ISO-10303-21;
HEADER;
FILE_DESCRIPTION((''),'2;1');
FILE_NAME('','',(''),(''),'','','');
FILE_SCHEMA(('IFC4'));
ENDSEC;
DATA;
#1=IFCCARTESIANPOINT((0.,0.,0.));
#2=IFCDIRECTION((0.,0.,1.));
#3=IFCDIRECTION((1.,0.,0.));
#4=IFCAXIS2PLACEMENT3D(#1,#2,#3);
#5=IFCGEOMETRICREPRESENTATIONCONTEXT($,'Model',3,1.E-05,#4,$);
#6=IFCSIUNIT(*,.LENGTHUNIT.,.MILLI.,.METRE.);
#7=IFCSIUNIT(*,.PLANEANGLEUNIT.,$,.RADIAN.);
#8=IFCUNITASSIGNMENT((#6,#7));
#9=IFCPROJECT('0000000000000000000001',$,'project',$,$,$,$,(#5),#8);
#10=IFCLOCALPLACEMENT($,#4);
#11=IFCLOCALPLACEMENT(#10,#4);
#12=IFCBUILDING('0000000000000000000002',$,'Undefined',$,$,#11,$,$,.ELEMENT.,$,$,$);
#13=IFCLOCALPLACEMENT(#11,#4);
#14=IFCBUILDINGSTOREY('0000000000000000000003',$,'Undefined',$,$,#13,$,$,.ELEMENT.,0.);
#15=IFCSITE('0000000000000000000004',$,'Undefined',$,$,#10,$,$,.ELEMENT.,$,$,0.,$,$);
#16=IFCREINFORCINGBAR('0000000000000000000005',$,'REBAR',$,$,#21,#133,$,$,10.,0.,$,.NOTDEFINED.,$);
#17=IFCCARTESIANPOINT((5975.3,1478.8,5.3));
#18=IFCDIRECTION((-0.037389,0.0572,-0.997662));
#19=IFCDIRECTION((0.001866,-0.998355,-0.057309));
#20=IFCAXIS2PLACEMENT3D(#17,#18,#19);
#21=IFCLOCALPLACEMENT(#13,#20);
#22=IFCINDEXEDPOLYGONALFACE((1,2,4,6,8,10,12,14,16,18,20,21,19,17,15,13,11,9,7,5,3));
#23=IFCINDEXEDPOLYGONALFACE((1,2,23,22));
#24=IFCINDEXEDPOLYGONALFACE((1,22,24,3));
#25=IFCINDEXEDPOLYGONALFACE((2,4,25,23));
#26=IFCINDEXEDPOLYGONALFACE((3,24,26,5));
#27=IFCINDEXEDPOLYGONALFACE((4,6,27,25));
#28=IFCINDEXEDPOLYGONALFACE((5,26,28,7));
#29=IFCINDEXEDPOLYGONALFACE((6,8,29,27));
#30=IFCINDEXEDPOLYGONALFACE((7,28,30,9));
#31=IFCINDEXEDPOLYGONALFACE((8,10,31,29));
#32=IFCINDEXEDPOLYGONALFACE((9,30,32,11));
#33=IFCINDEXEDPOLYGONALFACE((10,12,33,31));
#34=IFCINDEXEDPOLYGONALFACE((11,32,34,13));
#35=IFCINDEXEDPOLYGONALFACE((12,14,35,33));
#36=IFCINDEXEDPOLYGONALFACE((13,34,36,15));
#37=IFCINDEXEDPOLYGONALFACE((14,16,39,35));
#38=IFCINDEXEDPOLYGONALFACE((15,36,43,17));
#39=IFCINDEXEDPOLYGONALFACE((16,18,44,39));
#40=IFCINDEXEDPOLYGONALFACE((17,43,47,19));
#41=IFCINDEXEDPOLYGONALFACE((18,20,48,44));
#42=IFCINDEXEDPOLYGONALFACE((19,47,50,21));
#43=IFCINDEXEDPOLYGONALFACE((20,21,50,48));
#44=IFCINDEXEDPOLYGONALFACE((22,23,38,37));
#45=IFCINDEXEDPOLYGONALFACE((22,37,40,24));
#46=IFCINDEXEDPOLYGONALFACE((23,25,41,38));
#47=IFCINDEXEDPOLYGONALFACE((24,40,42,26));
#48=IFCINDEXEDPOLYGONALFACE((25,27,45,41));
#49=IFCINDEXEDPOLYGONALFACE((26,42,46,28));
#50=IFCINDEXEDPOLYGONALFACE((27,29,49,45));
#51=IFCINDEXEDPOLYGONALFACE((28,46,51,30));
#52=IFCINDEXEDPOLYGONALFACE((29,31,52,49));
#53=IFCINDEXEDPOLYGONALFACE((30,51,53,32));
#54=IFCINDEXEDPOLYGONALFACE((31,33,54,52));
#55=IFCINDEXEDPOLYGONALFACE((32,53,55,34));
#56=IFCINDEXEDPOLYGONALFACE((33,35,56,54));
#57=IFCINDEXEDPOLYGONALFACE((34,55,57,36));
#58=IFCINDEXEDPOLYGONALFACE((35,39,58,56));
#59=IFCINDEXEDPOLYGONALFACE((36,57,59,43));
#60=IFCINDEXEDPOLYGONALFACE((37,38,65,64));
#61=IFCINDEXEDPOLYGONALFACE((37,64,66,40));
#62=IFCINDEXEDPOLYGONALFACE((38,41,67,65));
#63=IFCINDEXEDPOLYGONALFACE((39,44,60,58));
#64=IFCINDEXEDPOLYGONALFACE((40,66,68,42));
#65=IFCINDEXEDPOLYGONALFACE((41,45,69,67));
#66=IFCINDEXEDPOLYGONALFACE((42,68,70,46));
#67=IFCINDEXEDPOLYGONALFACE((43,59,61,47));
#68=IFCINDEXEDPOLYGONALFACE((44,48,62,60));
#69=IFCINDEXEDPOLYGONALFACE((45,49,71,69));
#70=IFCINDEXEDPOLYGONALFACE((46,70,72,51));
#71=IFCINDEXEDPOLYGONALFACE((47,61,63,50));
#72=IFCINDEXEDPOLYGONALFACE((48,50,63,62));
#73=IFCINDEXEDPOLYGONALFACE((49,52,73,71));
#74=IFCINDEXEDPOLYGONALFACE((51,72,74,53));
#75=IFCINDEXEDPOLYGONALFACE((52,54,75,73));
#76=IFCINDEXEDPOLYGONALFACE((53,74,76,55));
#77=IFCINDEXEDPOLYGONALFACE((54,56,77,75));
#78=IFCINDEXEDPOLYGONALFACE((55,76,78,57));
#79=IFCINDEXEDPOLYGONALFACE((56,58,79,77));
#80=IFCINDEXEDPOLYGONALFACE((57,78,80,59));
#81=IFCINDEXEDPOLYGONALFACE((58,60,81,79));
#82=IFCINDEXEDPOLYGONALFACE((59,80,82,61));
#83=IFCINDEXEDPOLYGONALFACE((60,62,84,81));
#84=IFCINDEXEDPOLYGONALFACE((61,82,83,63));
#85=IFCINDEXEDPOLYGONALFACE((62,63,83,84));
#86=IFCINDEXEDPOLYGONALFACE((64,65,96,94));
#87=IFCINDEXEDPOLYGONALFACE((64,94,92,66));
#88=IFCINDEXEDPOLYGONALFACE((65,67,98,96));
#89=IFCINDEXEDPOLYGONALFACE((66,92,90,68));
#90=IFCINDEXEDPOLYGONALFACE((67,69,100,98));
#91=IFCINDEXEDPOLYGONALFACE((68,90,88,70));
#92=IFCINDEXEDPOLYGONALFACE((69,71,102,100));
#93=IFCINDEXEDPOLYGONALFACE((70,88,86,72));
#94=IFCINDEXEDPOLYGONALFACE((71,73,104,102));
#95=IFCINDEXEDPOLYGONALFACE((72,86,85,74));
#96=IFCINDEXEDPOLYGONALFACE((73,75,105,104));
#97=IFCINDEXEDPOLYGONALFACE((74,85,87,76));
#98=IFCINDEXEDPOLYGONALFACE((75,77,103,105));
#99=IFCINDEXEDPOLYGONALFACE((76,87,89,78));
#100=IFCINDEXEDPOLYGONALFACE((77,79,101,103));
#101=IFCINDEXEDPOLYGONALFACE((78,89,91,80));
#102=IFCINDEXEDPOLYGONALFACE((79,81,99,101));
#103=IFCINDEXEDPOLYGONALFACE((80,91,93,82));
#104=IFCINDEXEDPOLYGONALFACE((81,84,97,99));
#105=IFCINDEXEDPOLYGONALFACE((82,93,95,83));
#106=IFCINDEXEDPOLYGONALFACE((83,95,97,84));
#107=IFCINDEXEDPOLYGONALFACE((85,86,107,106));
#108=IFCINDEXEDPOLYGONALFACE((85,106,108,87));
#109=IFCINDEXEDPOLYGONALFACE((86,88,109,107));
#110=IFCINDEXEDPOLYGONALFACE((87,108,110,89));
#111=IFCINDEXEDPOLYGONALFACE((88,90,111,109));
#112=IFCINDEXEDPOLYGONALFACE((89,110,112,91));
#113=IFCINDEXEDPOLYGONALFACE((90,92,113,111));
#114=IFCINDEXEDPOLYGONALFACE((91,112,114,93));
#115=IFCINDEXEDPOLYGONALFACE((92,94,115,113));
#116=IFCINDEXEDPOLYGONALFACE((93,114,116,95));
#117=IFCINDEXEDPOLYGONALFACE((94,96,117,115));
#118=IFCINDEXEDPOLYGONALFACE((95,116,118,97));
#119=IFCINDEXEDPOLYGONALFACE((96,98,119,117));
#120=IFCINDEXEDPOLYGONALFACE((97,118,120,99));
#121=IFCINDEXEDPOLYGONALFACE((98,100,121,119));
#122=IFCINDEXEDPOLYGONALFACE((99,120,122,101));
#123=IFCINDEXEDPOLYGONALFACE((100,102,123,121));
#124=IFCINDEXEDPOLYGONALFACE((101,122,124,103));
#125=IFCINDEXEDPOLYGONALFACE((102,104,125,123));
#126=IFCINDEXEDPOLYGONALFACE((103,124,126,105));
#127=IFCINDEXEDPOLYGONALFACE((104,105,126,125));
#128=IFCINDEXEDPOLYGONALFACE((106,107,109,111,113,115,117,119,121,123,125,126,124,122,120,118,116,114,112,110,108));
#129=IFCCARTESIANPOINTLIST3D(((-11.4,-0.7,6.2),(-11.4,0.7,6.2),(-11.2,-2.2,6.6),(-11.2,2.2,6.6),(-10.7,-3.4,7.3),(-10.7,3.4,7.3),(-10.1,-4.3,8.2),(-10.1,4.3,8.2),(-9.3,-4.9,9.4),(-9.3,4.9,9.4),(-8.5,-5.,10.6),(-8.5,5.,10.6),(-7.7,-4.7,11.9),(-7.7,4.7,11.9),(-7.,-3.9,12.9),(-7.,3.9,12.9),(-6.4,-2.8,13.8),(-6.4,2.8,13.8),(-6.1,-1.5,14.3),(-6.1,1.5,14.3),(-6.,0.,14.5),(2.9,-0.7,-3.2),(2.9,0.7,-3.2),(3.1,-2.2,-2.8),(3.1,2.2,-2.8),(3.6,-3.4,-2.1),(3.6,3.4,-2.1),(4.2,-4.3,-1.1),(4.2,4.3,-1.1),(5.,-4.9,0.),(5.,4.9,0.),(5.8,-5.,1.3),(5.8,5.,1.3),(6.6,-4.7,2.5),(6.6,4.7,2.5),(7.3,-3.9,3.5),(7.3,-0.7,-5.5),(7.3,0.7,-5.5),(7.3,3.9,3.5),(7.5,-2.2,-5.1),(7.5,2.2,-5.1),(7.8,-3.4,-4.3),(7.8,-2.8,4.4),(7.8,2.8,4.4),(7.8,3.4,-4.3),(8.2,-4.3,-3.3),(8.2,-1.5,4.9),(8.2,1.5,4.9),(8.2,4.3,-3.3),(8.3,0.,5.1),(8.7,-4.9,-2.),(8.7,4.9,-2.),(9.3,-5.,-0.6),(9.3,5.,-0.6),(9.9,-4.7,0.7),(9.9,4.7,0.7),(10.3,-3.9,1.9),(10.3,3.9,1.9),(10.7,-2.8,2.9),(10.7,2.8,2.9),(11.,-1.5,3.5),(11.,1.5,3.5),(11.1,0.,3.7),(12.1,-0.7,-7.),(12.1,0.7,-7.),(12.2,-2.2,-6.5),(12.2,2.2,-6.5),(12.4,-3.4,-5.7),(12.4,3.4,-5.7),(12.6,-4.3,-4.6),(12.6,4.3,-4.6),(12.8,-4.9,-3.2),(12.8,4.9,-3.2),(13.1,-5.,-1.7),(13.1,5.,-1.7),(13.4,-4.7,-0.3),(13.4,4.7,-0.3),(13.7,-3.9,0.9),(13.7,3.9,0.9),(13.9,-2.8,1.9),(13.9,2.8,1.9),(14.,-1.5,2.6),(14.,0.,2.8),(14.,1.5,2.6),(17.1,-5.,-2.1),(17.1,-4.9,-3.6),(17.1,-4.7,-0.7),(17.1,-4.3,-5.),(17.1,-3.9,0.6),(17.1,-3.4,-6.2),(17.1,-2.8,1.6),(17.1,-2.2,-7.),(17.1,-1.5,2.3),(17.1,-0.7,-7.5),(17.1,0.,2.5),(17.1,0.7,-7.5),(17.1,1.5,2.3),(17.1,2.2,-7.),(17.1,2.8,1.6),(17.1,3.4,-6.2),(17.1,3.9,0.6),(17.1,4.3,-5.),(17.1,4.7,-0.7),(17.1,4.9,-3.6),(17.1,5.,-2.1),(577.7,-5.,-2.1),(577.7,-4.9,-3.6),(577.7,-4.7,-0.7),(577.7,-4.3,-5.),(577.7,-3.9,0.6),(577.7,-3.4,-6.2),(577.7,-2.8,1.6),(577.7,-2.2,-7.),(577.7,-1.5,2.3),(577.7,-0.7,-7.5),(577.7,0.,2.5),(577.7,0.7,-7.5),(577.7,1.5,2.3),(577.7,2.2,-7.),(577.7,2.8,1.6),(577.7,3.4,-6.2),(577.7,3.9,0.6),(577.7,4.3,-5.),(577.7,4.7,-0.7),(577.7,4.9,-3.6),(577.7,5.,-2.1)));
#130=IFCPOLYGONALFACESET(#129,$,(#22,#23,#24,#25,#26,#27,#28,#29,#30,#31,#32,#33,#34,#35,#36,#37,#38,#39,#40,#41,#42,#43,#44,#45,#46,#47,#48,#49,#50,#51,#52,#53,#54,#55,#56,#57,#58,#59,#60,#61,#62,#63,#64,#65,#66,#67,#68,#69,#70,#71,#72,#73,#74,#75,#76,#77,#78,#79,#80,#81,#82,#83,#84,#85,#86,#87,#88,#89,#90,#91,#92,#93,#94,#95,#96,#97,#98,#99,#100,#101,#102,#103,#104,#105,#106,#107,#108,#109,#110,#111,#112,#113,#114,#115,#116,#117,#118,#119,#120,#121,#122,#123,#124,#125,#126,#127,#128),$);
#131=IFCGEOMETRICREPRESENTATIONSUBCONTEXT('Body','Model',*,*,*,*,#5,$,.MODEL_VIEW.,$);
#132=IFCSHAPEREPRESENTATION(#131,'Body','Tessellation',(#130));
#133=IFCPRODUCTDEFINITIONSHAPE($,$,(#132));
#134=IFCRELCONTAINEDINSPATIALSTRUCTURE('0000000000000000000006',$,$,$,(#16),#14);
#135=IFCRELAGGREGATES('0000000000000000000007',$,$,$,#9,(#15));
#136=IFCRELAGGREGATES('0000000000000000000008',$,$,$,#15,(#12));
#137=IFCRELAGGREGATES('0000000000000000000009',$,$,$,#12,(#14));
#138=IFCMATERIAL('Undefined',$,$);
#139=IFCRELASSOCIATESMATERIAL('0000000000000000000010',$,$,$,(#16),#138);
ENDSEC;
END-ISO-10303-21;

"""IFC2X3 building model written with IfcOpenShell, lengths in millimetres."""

from ifc_helpers import new_model, entity, si_unit, frame, origin_with_axes, place, context, subcontext, project, spatial, source, transform, mapped, material, element, save


model = new_model("IFC2X3")

# Units and contexts
model_context = context("Model", 3, precision=1e-05, world=origin_with_axes())
body_context = subcontext(model_context, "Body", "Model", "MODEL_VIEW")
ifc_project = project(units=[si_unit("LENGTHUNIT", "METRE", prefix="MILLI"), si_unit("PLANEANGLEUNIT", "RADIAN")], contexts=[model_context])

# Site, building, storey
site_placement = place(None, origin_with_axes())
site = spatial("IfcSite", under=ifc_project, at=site_placement, Name="Undefined", CompositionType="ELEMENT", RefElevation=0.0)
building_placement = place(site_placement, origin_with_axes())
building = spatial("IfcBuilding", under=site, at=building_placement, Name="Undefined", CompositionType="ELEMENT")
storey_placement = place(building_placement, origin_with_axes())
storey = spatial("IfcBuildingStorey", under=building, at=storey_placement, Name="Undefined", CompositionType="ELEMENT", Elevation=0.0)

# Reinforcing bar
ifc_material_1 = material(Name="Undefined")
shared_shape_1 = source(origin_with_axes(), body_context, "Body", "AdvancedSweptSolid", [
    entity("IfcSweptDiskSolid", entity("IfcCompositeCurve", [entity("IfcCompositeCurveSegment", "CONTINUOUS", True, entity("IfcTrimmedCurve", entity("IfcLine", entity("IfcCartesianPoint", [0.0, 0.0, 0.0]), entity("IfcVector", entity("IfcDirection", [0.835483, 0.0, -0.549516]), 1.0)), [entity("IfcParameterValue", 0.0)], [entity("IfcParameterValue", 17.082101)], True, "PARAMETER")), entity("IfcCompositeCurveSegment", "CONTINUOUS", True, entity("IfcTrimmedCurve", entity("IfcCircle", entity("IfcAxis2Placement3D", entity("IfcCartesianPoint", [25.8, 0.0, 8.2]), entity("IfcDirection", [0.0, -1.0, 0.0]), entity("IfcDirection", [-0.549516, 0.0, -0.835483])), 21.0), [entity("IfcParameterValue", 0.0)], [entity("IfcParameterValue", 0.581785)], True, "PARAMETER")), entity("IfcCompositeCurveSegment", "DISCONTINUOUS", True, entity("IfcTrimmedCurve", entity("IfcLine", entity("IfcCartesianPoint", [25.8, 0.0, -12.8]), entity("IfcVector", entity("IfcDirection", [1.0, 0.0, 0.0]), 1.0)), [entity("IfcParameterValue", 0.0)], [entity("IfcParameterValue", 560.593055)], True, "PARAMETER"))], False), 5.0, None, 0.0, 578.3),
])
reinforcing_bar_1_placement = place(storey_placement, frame((5975.3, 1478.8, 5.3), z_axis=(-0.037389, 0.0572, -0.997662), x_axis=(0.001866, -0.998355, -0.057309)))
element("IfcReinforcingBar", 1, at=reinforcing_bar_1_placement, inside=storey, material=ifc_material_1, Name="REBAR", BarRole="NOTDEFINED", CrossSectionArea=0.0, NominalDiameter=10.0, context=body_context, shape_type="MappedRepresentation", body=[
    mapped(shared_shape_1, transform((-8.7, 0.0, 10.3))),
])

save(model, "model.ifc")
